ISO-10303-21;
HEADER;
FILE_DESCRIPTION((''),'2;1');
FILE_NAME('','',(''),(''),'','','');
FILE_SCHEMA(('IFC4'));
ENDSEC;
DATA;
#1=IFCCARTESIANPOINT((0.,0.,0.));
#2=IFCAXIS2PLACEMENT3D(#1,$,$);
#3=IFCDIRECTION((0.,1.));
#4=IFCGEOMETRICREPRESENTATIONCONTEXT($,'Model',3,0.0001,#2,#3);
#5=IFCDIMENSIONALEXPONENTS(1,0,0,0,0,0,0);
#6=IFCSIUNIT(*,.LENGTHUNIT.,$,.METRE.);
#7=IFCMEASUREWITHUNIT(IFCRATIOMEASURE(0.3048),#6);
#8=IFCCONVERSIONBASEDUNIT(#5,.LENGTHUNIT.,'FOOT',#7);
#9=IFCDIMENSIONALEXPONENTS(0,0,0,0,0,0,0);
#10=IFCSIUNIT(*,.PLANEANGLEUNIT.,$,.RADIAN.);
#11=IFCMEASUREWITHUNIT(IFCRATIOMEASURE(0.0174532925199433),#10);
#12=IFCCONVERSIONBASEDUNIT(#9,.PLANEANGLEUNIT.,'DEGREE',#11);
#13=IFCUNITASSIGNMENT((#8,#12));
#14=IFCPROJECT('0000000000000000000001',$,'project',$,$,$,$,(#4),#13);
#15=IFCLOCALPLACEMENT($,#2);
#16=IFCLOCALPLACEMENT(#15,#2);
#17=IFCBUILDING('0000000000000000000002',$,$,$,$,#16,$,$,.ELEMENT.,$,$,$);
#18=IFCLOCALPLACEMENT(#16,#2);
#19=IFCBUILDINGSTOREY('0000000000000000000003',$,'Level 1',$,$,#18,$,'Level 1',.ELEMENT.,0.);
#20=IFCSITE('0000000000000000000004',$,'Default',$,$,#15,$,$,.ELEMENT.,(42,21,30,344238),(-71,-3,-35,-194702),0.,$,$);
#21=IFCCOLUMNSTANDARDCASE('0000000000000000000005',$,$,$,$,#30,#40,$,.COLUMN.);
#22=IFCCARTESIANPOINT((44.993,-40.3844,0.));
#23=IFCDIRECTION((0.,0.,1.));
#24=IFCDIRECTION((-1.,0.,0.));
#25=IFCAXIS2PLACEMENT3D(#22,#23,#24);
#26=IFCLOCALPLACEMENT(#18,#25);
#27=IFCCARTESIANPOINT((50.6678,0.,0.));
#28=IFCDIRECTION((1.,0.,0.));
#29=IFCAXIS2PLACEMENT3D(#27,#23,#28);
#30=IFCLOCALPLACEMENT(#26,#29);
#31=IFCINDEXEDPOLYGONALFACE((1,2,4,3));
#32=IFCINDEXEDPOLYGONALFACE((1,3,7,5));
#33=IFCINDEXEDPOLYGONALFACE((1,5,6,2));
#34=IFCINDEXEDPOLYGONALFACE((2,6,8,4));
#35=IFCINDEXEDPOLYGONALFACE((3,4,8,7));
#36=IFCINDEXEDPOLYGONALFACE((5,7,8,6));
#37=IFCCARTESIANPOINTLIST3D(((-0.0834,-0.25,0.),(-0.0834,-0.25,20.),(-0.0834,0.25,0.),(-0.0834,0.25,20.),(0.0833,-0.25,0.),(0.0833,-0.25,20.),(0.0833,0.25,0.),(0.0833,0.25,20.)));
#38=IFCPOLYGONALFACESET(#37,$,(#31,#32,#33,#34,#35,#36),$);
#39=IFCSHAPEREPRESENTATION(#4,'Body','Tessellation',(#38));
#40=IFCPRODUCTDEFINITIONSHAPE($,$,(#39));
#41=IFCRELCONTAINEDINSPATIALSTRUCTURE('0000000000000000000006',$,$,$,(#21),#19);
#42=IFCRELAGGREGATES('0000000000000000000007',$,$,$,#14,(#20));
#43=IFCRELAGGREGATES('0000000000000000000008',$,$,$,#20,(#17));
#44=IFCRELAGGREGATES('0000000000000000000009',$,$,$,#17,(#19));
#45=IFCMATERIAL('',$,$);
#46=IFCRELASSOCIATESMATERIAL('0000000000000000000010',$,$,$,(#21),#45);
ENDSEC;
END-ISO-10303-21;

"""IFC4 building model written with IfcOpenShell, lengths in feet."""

from ifc_helpers import new_model, entity, si_unit, converted_unit, direction, frame, origin, place, context, project, spatial, rectangle, extrude, material, element, save


model = new_model("IFC4")

# Units and contexts
model_context = context("Model", 3, precision=0.0001, world=origin(), true_north=direction((0.0, 1.0)))
ifc_project = project(units=[converted_unit("LENGTHUNIT", "FOOT", entity("IfcRatioMeasure", 0.3048), si_unit("LENGTHUNIT", "METRE"), dimensions=[1, 0, 0, 0, 0, 0, 0]), converted_unit("PLANEANGLEUNIT", "DEGREE", entity("IfcRatioMeasure", 0.0174532925199433), si_unit("PLANEANGLEUNIT", "RADIAN"), dimensions=[0, 0, 0, 0, 0, 0, 0])], contexts=[model_context])

# Site, building, storey
site_placement = place(None, origin())
site = spatial("IfcSite", under=ifc_project, at=site_placement, Name="Default", CompositionType="ELEMENT", RefLatitude=(42, 21, 30, 344238), RefLongitude=(-71, -3, -35, -194702), RefElevation=0.0)
building_placement = place(site_placement, origin())
building = spatial("IfcBuilding", under=site, at=building_placement, CompositionType="ELEMENT")
storey_placement = place(building_placement, origin())
storey = spatial("IfcBuildingStorey", under=building, at=storey_placement, Name="Level 1", LongName="Level 1", CompositionType="ELEMENT", Elevation=0.0)

# Column
ifc_material = material(Name="")
placement_1 = place(storey_placement, frame((44.993, -40.3844, 0.0), z_axis=(0.0, 0.0, 1.0), x_axis=(-1.0, 0.0, 0.0)))
for number, where, z_axis, x_axis in (
    (1, (50.6678, 0.0, 0.0), (0.0, 0.0, 1.0), (1.0, 0.0, 0.0)),
):
    element("IfcColumnStandardCase", number, at=place(placement_1, frame(where, z_axis=z_axis, x_axis=x_axis)), inside=storey, material=ifc_material, PredefinedType="COLUMN", context=model_context, shape_type="SweptSolid", body=[
        extrude(rectangle(XDim=0.1667, YDim=0.5), origin(), (0.0, 0.0, 1.0), 20.0),
    ])

save(model, "model.ifc")
